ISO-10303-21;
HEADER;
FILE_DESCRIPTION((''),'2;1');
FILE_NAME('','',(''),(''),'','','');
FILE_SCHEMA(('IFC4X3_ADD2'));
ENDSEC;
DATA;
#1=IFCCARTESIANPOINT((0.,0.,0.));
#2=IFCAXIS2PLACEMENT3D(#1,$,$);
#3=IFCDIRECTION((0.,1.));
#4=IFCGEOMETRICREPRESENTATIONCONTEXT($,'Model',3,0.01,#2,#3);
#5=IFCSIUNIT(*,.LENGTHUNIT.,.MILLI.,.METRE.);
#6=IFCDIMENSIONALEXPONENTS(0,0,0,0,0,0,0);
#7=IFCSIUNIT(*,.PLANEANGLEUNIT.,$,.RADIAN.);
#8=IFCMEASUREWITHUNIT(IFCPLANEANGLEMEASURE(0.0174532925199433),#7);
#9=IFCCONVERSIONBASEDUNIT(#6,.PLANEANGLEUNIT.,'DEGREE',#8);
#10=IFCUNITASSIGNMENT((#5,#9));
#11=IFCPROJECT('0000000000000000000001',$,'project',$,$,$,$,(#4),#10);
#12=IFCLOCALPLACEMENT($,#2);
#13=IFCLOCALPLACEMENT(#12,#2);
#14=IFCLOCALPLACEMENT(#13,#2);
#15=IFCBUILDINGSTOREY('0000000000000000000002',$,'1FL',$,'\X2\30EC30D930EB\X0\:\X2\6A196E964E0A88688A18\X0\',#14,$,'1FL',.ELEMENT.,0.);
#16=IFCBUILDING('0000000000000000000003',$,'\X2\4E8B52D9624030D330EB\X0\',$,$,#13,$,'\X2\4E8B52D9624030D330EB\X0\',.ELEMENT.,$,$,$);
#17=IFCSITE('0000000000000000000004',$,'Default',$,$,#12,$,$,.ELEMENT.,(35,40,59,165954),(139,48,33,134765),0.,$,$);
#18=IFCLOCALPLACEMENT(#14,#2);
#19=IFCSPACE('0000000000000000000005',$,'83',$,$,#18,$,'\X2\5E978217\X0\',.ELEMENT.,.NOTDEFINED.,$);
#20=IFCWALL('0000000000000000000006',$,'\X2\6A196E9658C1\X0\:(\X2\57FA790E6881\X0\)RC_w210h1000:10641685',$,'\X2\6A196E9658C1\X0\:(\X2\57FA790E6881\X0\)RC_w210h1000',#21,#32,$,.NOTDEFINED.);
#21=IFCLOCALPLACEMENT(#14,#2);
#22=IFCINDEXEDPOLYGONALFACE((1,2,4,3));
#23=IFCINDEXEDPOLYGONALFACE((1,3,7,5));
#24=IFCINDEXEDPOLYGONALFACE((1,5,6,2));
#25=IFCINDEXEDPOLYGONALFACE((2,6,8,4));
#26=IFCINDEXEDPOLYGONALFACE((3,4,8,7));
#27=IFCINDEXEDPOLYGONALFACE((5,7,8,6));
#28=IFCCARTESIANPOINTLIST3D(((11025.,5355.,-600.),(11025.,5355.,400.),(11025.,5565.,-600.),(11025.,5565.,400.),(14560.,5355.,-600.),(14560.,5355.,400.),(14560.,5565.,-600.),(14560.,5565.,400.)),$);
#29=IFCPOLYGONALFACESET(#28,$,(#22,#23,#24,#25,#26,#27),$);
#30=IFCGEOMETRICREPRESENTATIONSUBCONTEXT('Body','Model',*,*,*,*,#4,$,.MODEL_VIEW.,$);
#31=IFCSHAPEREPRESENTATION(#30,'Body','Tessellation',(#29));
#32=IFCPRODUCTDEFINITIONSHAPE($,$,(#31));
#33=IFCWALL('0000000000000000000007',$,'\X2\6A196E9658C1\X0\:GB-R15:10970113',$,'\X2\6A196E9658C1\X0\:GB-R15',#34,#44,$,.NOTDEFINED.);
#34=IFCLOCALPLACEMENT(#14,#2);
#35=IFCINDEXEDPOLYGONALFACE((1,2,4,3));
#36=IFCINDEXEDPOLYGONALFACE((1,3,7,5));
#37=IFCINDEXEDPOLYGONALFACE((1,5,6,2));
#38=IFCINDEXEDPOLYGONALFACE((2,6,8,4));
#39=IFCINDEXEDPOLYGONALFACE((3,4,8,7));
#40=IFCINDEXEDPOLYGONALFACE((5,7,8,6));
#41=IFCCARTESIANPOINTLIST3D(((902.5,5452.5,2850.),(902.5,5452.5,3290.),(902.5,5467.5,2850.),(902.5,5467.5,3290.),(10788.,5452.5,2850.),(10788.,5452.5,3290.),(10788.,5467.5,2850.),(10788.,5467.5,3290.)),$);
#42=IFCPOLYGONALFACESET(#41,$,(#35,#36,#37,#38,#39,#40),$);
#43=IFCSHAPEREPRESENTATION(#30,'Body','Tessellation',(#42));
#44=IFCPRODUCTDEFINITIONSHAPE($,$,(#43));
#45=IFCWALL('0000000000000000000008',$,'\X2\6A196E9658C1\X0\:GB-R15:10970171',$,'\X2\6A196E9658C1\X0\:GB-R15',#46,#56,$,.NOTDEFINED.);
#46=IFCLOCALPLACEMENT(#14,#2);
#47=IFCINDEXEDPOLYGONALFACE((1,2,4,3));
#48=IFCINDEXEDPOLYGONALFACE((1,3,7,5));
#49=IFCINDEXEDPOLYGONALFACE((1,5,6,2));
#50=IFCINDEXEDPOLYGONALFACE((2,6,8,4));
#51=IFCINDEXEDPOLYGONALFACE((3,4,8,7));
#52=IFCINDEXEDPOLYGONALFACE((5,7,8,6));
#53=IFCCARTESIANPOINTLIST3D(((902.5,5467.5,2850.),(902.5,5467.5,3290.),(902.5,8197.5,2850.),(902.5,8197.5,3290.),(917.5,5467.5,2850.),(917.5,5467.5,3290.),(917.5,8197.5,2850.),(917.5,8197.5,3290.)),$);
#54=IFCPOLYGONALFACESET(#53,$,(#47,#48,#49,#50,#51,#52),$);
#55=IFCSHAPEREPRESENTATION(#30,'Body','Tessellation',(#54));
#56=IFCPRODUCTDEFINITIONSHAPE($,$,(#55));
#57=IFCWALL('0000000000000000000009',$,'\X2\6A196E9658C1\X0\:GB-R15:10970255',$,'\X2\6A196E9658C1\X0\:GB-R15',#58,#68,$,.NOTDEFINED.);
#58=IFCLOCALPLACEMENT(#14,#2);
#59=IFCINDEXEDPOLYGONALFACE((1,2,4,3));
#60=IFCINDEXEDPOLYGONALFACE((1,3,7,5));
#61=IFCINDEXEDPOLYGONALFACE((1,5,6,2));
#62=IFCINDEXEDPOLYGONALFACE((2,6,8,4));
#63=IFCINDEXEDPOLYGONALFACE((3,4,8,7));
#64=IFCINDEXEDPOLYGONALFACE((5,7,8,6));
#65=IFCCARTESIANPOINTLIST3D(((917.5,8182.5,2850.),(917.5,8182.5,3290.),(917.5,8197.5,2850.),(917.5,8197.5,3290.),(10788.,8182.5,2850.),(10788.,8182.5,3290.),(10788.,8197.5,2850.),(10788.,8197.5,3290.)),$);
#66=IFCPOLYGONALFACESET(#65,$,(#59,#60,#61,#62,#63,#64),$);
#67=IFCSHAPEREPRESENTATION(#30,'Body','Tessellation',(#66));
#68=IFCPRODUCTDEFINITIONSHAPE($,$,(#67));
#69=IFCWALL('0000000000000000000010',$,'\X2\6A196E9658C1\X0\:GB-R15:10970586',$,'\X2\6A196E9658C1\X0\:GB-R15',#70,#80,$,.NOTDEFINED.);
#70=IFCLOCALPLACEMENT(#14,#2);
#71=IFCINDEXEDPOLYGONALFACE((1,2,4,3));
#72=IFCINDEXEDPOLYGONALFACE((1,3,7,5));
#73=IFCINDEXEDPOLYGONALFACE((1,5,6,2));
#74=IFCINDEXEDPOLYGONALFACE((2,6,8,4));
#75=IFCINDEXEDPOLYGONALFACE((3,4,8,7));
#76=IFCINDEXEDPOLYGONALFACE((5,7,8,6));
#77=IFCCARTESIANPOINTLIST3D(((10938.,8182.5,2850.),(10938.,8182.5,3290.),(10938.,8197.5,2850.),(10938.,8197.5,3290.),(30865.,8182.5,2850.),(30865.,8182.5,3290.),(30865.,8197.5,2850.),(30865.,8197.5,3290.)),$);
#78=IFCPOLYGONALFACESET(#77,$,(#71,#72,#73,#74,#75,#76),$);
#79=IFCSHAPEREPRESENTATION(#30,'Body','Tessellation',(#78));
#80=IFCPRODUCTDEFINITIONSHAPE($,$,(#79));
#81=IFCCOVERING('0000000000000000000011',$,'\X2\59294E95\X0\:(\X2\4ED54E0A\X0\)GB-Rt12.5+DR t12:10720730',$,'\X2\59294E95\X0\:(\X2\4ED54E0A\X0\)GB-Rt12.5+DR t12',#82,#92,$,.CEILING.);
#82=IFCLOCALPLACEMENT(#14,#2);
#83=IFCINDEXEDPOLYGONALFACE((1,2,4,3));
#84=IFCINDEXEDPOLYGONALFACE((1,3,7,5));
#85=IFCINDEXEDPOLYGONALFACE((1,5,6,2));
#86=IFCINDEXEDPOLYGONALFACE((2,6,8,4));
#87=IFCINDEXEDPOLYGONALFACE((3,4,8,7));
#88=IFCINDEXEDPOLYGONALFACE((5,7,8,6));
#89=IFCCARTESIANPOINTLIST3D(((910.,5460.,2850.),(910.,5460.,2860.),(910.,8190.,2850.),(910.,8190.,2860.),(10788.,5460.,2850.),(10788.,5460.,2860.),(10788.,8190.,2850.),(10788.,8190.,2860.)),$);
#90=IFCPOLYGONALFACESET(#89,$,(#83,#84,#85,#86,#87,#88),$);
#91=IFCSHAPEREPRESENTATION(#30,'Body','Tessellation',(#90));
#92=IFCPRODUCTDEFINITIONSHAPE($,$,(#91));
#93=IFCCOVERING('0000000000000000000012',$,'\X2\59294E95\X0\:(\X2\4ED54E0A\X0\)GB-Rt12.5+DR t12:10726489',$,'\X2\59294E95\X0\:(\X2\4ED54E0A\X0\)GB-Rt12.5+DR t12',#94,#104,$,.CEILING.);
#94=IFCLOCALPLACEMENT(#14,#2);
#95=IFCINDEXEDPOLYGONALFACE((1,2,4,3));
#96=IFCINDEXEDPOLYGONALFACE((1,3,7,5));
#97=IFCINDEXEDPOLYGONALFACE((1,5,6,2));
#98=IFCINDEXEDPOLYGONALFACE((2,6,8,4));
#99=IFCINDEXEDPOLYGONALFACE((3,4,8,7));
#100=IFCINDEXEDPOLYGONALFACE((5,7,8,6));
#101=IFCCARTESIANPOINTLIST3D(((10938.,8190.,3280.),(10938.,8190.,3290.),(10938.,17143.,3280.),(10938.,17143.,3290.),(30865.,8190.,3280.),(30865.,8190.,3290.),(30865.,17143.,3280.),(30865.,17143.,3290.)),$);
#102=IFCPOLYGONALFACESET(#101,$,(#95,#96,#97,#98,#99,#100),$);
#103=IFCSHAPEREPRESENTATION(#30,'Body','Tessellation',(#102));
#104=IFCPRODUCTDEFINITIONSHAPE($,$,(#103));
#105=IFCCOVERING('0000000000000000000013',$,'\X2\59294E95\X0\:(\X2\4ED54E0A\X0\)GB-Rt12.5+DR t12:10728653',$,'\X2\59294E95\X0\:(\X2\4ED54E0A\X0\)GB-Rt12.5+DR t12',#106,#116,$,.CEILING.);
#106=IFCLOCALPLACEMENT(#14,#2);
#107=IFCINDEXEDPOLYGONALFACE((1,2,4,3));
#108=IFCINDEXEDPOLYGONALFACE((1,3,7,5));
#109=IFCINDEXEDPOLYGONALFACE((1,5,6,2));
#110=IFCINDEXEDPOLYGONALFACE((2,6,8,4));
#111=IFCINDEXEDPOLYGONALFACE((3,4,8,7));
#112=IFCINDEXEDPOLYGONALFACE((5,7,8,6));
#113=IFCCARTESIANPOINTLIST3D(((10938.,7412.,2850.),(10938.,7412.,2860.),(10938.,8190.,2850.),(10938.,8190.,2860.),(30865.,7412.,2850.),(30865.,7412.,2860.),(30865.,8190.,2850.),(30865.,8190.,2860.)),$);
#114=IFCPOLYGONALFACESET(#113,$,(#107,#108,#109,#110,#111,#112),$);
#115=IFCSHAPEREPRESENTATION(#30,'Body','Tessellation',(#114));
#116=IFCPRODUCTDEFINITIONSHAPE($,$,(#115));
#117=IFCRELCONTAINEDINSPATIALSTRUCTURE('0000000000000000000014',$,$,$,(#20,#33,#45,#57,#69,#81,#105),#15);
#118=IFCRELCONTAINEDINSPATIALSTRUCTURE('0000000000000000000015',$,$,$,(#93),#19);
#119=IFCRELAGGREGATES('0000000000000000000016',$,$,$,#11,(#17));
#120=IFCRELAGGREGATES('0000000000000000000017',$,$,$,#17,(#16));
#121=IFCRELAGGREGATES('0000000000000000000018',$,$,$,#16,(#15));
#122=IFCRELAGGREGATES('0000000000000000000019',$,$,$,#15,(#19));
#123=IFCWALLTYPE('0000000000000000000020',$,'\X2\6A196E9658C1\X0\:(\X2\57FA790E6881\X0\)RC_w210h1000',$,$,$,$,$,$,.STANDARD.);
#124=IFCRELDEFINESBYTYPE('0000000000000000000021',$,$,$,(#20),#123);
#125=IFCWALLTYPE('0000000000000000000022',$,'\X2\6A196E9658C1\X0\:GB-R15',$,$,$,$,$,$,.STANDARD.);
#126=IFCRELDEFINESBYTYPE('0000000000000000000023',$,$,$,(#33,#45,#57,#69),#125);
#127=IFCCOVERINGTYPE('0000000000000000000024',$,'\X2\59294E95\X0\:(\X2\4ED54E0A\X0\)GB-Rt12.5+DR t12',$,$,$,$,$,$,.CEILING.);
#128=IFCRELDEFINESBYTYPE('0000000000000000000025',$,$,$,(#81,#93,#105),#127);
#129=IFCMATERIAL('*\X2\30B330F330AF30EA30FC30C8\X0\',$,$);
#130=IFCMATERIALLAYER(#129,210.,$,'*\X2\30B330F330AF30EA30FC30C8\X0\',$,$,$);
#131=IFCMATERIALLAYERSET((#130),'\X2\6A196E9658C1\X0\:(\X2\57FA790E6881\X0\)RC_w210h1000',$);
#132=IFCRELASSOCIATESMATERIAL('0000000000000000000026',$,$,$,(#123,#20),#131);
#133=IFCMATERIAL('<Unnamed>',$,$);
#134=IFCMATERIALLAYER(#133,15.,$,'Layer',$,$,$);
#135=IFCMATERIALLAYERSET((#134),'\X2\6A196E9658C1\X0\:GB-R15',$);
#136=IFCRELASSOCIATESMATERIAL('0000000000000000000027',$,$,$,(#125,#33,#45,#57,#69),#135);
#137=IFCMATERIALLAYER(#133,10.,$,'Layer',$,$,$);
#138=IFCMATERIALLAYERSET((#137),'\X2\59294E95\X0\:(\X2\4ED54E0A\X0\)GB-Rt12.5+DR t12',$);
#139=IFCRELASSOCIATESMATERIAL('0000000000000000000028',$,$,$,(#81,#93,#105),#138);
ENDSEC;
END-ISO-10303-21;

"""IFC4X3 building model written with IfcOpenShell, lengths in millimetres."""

from ifc_helpers import new_model, entity, si_unit, converted_unit, direction, frame, frame_2d, origin, place, context, subcontext, project, spatial, rectangle, extrude, material, layer, layer_set, layer_usage, type_object, element, save


model = new_model("IFC4X3")

# Units and contexts
model_context = context("Model", 3, precision=0.01, world=origin(), true_north=direction((0.0, 1.0)))
body_context = subcontext(model_context, "Body", "Model", "MODEL_VIEW")
ifc_project = project(units=[si_unit("LENGTHUNIT", "METRE", prefix="MILLI"), converted_unit("PLANEANGLEUNIT", "DEGREE", entity("IfcPlaneAngleMeasure", 0.0174532925199433), si_unit("PLANEANGLEUNIT", "RADIAN"), dimensions=[0, 0, 0, 0, 0, 0, 0])], contexts=[model_context])

# Site, building, storey
site_placement = place(None, origin())
site = spatial("IfcSite", under=ifc_project, at=site_placement, Name="Default", CompositionType="ELEMENT", RefLatitude=(35, 40, 59, 165954), RefLongitude=(139, 48, 33, 134765), RefElevation=0.0)
building_placement = place(site_placement, origin())
building = spatial("IfcBuilding", under=site, at=building_placement, Name="事務所ビル", LongName="事務所ビル", CompositionType="ELEMENT")
storey_placement = place(building_placement, origin())
storey = spatial("IfcBuildingStorey", under=building, at=storey_placement, Name="1FL", ObjectType="レベル:標準上表記", LongName="1FL", CompositionType="ELEMENT", Elevation=0.0)

# Shared definitions
ifc_material_1 = material(Name="<Unnamed>")

# Shared definitions
ifc_material_2 = material(Name="*コンクリート")

# Wall
ifc_layer_1 = layer(ifc_material_2, 210.0, Name="*コンクリート")
ifc_layer_set_1 = layer_set([ifc_layer_1], Name="標準壁:(基礎梁)RC_w210h1000")
wall_type_1 = type_object("IfcWallType", Name="標準壁:(基礎梁)RC_w210h1000", PredefinedType="STANDARD", material=ifc_layer_set_1)
wall_1_placement = place(storey_placement, frame((11025.0, 5460.0, -600.0)))
element("IfcWall", 1, at=wall_1_placement, inside=storey, type_object=wall_type_1, material=ifc_layer_set_1, Name="標準壁:(基礎梁)RC_w210h1000:10641685", ObjectType="標準壁:(基礎梁)RC_w210h1000", PredefinedType="NOTDEFINED", context=body_context, shape_type="SweptSolid", body=[
    extrude(rectangle(XDim=3535.0, YDim=210.0, at=frame_2d((1767.5, 0.0), x_axis=(-1.0, 0.0))), origin(), (0.0, 0.0, 1.0), 1000.0),
])

# Walls
ifc_layer_2 = layer(ifc_material_1, 15.0, Name="Layer")
ifc_layer_set_2 = layer_set([ifc_layer_2], Name="標準壁:GB-R15")
wall_type_2 = type_object("IfcWallType", Name="標準壁:GB-R15", PredefinedType="STANDARD", material=ifc_layer_set_2)
wall_2_placement = place(storey_placement, frame((10788.0, 5460.0, 2850.0), z_axis=(0.0, 0.0, 1.0), x_axis=(-1.0, 0.0, 0.0)))
element("IfcWall", 2, at=wall_2_placement, inside=storey, type_object=wall_type_2, material=ifc_layer_set_2, Name="標準壁:GB-R15:10970113", ObjectType="標準壁:GB-R15", PredefinedType="NOTDEFINED", context=body_context, shape_type="SweptSolid", body=[
    extrude(rectangle(XDim=9885.5, YDim=15.0, at=frame_2d((4942.8, 0.0), x_axis=(-1.0, 0.0))), origin(), (0.0, 0.0, 1.0), 440.0),
])
wall_3_placement = place(storey_placement, frame((910.0, 5467.5, 2850.0), z_axis=(0.0, 0.0, 1.0), x_axis=(0.0, 1.0, 0.0)))
element("IfcWall", 3, at=wall_3_placement, inside=storey, type_object=wall_type_2, material=ifc_layer_set_2, Name="標準壁:GB-R15:10970171", ObjectType="標準壁:GB-R15", PredefinedType="NOTDEFINED", context=body_context, shape_type="SweptSolid", body=[
    extrude(rectangle(XDim=2730.0, YDim=15.0, at=frame_2d((1365.0, 0.0), x_axis=(-1.0, 0.0))), origin(), (0.0, 0.0, 1.0), 440.0),
])
wall_4_placement = place(storey_placement, frame((917.5, 8190.0, 2850.0)))
element("IfcWall", 4, at=wall_4_placement, inside=storey, type_object=wall_type_2, material=ifc_layer_set_2, Name="標準壁:GB-R15:10970255", ObjectType="標準壁:GB-R15", PredefinedType="NOTDEFINED", context=body_context, shape_type="SweptSolid", body=[
    extrude(rectangle(XDim=9870.5, YDim=15.0, at=frame_2d((4935.2, 0.0), x_axis=(-1.0, 0.0))), origin(), (0.0, 0.0, 1.0), 440.0),
])
wall_5_placement = place(storey_placement, frame((10938.0, 8190.0, 2850.0)))
element("IfcWall", 5, at=wall_5_placement, inside=storey, type_object=wall_type_2, material=ifc_layer_set_2, Name="標準壁:GB-R15:10970586", ObjectType="標準壁:GB-R15", PredefinedType="NOTDEFINED", context=body_context, shape_type="SweptSolid", body=[
    extrude(rectangle(XDim=19927.0, YDim=15.0, at=frame_2d((9963.5, 0.0), x_axis=(-1.0, 0.0))), origin(), (0.0, 0.0, 1.0), 440.0),
])

# Covering
ifc_layer_3 = layer(ifc_material_1, 10.0, Name="Layer")
ifc_layer_set_3 = layer_set([ifc_layer_3], Name="天井:(仕上)GB-Rt12.5+DR t12")
ifc_layer_usage_1 = layer_usage(ifc_layer_set_3, "AXIS3", "NEGATIVE", 10.0)
covering_type = type_object("IfcCoveringType", Name="天井:(仕上)GB-Rt12.5+DR t12", PredefinedType="CEILING")
covering_1_placement = place(storey_placement, frame((910.0, 5460.0, 2850.0)))
element("IfcCovering", 6, at=covering_1_placement, inside=storey, type_object=covering_type, material=ifc_layer_usage_1, Name="天井:(仕上)GB-Rt12.5+DR t12:10720730", ObjectType="天井:(仕上)GB-Rt12.5+DR t12", PredefinedType="CEILING", context=body_context, shape_type="SweptSolid", body=[
    extrude(rectangle(XDim=9878.0, YDim=2730.0, at=frame_2d((0.0, 0.0), x_axis=(1.0, 0.0))), frame((4939.0, 1365.0, 0.0)), (0.0, 0.0, 1.0), 10.0),
])

# Shared definitions
space_1_placement = place(storey_placement, origin())
space_1 = spatial("IfcSpace", under=storey, at=space_1_placement, Name="83", LongName="店舗", CompositionType="ELEMENT", PredefinedType="NOTDEFINED")

# Coverings
ifc_layer_usage_2 = layer_usage(ifc_layer_set_3, "AXIS3", "NEGATIVE", 0.0)
covering_2_placement = place(space_1_placement, frame((10938.0, 8190.0, 3280.0)))
element("IfcCovering", 7, at=covering_2_placement, inside=space_1, type_object=covering_type, material=ifc_layer_usage_2, Name="天井:(仕上)GB-Rt12.5+DR t12:10726489", ObjectType="天井:(仕上)GB-Rt12.5+DR t12", PredefinedType="CEILING", context=body_context, shape_type="SweptSolid", body=[
    extrude(rectangle(XDim=8953.0, YDim=19927.0, at=frame_2d((0.0, 0.0), x_axis=(1.0, 0.0))), frame((9963.5, 4476.5, 0.0), z_axis=(0.0, 0.0, 1.0), x_axis=(0.0, 1.0, 0.0)), (0.0, 0.0, 1.0), 10.0),
])
ifc_layer_usage_3 = layer_usage(ifc_layer_set_3, "AXIS3", "NEGATIVE", 0.0)
covering_3_placement = place(storey_placement, frame((10938.0, 7412.0, 2850.0)))
element("IfcCovering", 8, at=covering_3_placement, inside=storey, type_object=covering_type, material=ifc_layer_usage_3, Name="天井:(仕上)GB-Rt12.5+DR t12:10728653", ObjectType="天井:(仕上)GB-Rt12.5+DR t12", PredefinedType="CEILING", context=body_context, shape_type="SweptSolid", body=[
    extrude(rectangle(XDim=19927.0, YDim=778.0, at=frame_2d((0.0, 0.0), x_axis=(1.0, 0.0))), frame((9963.5, 389.0, 0.0), z_axis=(0.0, 0.0, 1.0), x_axis=(-1.0, 0.0, 0.0)), (0.0, 0.0, 1.0), 10.0),
])

save(model, "model.ifc")
